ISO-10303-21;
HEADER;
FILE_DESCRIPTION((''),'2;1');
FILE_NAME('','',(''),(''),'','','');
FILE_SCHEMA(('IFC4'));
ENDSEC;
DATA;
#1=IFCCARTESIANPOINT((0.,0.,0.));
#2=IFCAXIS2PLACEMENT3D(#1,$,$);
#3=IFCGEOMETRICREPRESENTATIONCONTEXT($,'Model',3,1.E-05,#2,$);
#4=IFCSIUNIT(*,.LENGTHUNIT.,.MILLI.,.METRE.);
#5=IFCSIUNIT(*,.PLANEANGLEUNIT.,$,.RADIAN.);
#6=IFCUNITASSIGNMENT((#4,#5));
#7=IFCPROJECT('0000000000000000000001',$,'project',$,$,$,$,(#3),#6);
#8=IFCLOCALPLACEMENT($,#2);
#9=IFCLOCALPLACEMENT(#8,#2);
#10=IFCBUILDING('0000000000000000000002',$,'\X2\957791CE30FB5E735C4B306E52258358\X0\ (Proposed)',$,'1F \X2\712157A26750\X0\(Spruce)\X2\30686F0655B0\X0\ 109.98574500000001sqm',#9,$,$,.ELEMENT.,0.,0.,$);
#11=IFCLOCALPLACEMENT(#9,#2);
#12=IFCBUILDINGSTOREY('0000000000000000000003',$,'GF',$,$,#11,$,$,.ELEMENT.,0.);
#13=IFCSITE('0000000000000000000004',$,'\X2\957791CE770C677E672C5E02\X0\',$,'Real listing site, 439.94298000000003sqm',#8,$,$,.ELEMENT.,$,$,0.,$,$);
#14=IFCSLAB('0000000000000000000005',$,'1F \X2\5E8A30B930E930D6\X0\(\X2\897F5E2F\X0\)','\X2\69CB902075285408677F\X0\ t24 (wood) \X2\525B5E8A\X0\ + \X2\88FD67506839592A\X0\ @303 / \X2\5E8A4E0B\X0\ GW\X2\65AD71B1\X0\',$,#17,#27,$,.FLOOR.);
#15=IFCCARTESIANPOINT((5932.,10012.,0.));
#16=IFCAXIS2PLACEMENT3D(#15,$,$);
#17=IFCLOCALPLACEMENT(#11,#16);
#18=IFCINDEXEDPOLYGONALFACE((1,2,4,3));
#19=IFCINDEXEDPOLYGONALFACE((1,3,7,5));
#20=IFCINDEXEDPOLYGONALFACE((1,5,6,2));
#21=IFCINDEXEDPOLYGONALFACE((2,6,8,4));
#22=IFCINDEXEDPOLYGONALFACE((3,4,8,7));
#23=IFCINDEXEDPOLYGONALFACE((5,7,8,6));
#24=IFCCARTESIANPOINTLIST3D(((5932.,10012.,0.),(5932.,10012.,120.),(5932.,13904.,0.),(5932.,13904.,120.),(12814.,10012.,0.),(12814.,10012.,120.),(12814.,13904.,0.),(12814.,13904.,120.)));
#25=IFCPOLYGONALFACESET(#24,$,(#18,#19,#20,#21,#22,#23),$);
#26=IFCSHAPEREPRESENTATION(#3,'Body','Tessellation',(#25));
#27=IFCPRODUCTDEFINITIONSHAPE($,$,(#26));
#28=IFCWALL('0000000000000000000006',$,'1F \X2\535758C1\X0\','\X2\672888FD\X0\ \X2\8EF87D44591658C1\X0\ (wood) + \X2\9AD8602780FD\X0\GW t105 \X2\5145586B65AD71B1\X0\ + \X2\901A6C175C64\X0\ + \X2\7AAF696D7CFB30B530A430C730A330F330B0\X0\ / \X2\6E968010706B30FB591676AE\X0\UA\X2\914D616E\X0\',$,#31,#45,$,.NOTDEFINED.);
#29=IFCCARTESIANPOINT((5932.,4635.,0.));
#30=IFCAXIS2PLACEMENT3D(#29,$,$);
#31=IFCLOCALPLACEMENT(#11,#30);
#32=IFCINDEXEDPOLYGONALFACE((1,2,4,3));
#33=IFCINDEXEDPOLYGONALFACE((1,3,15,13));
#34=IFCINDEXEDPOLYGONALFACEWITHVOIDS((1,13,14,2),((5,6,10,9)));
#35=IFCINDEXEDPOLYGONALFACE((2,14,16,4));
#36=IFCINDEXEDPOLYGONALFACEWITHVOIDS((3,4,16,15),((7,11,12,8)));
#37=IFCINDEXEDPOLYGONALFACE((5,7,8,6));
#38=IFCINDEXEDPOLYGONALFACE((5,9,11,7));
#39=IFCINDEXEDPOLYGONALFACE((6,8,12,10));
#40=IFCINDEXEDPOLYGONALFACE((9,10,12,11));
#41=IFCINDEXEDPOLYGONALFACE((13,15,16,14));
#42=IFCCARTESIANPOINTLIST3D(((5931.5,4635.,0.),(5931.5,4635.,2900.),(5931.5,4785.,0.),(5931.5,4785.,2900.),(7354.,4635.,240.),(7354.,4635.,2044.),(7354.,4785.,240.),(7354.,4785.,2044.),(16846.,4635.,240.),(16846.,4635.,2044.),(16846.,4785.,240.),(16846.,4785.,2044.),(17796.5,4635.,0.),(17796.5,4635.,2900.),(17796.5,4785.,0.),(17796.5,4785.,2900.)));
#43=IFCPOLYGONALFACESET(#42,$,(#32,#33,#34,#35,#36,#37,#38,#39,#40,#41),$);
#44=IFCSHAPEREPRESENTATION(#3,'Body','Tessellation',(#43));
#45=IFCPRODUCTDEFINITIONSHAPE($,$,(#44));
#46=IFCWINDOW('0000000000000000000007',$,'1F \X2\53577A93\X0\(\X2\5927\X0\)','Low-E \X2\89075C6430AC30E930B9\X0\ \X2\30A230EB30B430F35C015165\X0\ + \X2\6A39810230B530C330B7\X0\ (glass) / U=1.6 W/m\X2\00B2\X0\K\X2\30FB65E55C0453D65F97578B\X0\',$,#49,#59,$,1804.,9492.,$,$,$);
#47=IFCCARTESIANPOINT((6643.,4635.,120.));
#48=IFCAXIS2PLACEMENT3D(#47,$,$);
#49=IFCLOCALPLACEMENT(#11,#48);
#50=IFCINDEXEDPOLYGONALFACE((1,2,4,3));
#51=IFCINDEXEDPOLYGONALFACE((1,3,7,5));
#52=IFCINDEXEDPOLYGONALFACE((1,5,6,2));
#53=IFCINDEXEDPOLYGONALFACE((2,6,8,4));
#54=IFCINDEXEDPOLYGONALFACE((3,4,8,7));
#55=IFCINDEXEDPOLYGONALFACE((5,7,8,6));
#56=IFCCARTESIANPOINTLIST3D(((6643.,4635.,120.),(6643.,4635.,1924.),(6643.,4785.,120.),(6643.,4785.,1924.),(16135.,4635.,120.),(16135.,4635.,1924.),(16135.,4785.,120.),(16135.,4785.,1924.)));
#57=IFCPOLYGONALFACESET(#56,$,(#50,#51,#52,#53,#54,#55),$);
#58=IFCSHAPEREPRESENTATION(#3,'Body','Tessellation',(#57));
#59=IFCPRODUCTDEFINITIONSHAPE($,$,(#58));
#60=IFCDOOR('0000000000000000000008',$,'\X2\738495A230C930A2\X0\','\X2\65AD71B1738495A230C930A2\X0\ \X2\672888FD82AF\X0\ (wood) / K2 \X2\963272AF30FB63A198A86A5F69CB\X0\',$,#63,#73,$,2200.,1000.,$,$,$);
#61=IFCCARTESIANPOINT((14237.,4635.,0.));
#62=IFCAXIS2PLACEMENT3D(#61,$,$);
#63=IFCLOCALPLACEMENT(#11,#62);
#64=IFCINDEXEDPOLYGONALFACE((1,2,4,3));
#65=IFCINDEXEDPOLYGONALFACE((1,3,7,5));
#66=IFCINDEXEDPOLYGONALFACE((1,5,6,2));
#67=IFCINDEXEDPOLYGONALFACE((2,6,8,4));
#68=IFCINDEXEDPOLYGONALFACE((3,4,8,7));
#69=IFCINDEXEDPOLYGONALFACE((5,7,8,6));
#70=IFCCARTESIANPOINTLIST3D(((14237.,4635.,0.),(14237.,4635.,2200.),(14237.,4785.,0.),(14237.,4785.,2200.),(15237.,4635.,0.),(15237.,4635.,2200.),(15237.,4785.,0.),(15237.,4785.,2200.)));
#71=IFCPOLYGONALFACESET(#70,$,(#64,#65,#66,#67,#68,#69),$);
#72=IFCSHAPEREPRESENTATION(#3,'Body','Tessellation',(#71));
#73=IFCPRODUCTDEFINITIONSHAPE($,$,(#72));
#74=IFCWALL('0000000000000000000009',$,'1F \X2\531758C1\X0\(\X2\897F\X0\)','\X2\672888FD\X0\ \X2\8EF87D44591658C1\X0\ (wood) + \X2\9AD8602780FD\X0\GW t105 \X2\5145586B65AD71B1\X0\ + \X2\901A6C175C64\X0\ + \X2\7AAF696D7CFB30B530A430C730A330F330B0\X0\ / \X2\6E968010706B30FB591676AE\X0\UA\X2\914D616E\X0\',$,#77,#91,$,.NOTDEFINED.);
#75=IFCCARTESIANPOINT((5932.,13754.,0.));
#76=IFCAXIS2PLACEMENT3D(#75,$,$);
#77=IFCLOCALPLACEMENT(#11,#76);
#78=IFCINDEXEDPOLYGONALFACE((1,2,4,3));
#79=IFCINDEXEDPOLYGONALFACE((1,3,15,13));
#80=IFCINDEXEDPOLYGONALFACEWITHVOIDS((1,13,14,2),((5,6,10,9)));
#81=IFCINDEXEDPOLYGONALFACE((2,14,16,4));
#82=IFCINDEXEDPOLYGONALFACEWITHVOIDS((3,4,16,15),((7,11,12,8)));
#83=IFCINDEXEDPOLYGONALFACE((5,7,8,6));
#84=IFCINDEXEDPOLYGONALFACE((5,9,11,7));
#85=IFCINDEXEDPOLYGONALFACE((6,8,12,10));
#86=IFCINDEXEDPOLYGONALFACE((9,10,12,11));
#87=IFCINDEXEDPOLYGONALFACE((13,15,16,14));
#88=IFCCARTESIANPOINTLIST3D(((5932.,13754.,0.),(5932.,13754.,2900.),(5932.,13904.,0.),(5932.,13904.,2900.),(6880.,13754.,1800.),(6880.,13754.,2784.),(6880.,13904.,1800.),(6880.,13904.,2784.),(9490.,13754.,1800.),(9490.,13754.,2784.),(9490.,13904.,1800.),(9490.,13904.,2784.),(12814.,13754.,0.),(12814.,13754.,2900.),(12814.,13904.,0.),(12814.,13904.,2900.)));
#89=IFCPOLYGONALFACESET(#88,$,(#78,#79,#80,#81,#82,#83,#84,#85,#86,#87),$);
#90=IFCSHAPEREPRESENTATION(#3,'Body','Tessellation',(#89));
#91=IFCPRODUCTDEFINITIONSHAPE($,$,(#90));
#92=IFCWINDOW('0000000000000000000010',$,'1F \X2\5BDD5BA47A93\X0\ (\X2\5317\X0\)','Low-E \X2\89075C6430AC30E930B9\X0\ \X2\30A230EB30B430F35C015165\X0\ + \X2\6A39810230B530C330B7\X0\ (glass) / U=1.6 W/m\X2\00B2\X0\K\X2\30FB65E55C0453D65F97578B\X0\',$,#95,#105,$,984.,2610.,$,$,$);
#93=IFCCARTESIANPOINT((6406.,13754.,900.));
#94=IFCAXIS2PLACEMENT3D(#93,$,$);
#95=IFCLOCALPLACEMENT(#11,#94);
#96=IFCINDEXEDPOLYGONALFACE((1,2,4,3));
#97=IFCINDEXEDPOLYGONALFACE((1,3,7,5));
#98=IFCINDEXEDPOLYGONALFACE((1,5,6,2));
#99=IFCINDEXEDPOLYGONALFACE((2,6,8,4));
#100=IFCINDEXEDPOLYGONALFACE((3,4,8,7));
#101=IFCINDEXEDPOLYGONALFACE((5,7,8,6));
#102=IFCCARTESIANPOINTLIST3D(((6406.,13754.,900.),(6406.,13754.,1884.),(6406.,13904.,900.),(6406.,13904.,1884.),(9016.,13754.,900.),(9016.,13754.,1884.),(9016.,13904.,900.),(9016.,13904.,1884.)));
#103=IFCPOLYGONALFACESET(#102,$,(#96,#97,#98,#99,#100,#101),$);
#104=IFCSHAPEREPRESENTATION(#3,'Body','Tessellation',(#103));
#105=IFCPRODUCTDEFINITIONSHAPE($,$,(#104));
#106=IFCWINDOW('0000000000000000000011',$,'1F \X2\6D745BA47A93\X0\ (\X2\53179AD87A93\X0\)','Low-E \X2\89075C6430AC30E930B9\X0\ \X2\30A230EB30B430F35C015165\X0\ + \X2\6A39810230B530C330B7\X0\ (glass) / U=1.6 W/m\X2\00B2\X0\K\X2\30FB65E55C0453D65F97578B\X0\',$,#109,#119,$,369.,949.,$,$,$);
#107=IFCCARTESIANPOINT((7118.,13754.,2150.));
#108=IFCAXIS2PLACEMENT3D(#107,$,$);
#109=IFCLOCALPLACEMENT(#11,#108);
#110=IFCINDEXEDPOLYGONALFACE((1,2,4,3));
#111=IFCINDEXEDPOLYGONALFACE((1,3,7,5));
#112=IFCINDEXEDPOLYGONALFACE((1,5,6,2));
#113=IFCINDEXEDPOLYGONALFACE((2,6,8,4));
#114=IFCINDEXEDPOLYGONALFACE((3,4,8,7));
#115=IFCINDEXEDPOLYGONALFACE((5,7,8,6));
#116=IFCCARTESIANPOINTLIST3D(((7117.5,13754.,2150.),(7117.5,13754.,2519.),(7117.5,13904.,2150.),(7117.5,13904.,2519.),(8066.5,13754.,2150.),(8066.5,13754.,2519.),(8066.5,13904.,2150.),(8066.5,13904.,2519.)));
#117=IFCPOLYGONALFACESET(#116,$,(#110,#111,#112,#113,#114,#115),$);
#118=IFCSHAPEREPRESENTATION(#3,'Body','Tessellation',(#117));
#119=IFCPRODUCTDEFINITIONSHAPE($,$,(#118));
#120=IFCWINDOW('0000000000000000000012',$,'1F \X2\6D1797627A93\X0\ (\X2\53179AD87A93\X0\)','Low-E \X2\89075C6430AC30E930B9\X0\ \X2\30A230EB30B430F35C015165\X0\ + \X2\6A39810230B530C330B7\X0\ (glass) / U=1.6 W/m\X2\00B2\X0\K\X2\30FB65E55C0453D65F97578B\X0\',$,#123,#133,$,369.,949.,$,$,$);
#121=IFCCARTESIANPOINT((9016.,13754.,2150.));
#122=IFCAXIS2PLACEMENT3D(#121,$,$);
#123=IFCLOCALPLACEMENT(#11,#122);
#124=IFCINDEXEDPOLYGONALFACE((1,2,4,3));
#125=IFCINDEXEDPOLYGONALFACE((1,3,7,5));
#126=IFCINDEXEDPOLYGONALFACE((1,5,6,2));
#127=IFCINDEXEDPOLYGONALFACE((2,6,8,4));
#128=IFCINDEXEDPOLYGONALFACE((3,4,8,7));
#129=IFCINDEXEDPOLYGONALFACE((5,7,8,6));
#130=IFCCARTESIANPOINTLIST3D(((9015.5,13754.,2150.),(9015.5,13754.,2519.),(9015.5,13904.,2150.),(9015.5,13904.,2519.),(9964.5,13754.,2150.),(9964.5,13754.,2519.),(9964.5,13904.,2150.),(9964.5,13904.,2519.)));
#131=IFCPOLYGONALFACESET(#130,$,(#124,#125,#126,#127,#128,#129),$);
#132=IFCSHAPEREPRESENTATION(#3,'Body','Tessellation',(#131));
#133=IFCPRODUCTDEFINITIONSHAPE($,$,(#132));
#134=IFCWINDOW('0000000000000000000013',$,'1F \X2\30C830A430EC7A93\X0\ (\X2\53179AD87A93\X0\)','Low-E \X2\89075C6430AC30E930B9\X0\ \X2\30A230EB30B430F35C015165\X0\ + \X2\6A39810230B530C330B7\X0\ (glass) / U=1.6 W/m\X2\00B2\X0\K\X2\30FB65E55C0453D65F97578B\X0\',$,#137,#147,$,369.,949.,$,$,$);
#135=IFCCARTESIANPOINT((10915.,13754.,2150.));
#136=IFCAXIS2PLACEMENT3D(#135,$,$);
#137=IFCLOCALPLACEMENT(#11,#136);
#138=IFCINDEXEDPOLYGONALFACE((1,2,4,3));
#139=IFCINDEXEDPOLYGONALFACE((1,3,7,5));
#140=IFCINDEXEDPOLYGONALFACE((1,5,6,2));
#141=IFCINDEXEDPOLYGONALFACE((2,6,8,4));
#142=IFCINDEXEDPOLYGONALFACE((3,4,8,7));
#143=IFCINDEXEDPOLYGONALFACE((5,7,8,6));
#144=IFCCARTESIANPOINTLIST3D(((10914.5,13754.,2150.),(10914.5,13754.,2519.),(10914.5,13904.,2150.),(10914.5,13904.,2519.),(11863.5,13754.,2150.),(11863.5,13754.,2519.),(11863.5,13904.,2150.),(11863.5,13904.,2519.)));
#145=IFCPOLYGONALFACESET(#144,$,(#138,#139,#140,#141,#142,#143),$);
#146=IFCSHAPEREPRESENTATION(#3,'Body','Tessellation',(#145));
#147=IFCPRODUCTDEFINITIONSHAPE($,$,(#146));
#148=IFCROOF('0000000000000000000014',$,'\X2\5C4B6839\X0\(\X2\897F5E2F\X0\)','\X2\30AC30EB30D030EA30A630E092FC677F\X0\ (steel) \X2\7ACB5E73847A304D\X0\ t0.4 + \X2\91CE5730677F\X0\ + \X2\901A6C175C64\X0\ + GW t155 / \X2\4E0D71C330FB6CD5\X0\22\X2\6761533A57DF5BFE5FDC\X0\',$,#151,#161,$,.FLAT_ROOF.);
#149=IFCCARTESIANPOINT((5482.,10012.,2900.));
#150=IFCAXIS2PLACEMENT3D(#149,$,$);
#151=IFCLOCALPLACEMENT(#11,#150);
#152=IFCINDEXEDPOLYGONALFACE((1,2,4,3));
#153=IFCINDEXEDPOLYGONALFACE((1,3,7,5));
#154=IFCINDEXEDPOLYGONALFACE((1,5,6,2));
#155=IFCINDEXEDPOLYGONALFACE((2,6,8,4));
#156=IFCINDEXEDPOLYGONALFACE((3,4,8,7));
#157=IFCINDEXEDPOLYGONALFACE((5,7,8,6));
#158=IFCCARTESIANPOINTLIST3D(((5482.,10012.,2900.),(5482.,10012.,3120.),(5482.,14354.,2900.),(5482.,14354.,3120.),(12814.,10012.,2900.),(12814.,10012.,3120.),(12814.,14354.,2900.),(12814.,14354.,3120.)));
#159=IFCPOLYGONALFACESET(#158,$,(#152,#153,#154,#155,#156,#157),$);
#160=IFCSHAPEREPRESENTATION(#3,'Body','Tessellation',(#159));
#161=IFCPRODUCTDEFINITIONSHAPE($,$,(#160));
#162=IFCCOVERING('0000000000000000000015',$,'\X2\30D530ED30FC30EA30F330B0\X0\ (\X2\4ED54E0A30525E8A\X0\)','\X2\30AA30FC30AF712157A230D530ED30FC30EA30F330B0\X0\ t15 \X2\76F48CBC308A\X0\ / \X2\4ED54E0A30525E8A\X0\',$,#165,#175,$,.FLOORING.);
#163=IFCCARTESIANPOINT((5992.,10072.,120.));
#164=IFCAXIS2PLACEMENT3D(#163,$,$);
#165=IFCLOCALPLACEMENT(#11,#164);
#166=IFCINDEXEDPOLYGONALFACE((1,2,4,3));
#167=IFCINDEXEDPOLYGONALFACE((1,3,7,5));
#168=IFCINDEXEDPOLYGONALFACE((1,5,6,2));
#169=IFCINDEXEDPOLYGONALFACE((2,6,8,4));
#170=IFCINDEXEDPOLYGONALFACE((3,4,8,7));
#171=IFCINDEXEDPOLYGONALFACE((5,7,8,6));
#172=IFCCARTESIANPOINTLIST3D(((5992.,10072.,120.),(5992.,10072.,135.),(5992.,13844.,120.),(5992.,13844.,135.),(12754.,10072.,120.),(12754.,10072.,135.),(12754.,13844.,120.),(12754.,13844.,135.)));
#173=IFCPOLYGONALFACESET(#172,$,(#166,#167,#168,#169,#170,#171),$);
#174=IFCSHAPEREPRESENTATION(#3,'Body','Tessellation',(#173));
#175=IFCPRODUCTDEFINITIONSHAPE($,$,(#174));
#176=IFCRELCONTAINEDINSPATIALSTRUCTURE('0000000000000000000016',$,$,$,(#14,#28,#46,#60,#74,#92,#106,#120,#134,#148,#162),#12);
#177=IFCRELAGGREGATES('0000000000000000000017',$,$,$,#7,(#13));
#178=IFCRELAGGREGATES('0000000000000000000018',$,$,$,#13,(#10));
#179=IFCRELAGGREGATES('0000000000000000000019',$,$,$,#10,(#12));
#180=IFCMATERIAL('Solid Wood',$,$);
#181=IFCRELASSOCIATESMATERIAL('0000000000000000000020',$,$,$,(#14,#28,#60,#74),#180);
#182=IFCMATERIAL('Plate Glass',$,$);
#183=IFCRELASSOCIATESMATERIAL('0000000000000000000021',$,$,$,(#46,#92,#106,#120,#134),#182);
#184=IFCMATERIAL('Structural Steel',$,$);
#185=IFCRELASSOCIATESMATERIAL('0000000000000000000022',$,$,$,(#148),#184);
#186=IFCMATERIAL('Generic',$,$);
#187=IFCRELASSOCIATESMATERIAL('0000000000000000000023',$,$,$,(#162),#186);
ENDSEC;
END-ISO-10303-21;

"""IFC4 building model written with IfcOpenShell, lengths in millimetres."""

from ifc_helpers import new_model, si_unit, frame, frame_2d, origin, place, context, project, spatial, rectangle, extrude, material, element, fill, save


model = new_model("IFC4")

# Units and contexts
model_context = context("Model", 3, precision=1e-05, world=origin())
ifc_project = project(units=[si_unit("LENGTHUNIT", "METRE", prefix="MILLI"), si_unit("PLANEANGLEUNIT", "RADIAN")], contexts=[model_context])

# Site, building, storey
site_placement = place(None, origin())
site = spatial("IfcSite", under=ifc_project, at=site_placement, Name="長野県松本市", ObjectType="Real listing site, 439.94298000000003sqm", CompositionType="ELEMENT", RefElevation=0.0)
building_placement = place(site_placement, origin())
building = spatial("IfcBuilding", under=site, at=building_placement, Name="長野・平屋の別荘 (Proposed)", ObjectType="1F 無垢材(Spruce)と漆喰 109.98574500000001sqm", CompositionType="ELEMENT", ElevationOfRefHeight=0.0, ElevationOfTerrain=0.0)
storey_placement = place(building_placement, origin())
storey = spatial("IfcBuildingStorey", under=building, at=storey_placement, Name="GF", CompositionType="ELEMENT", Elevation=0.0)

# Slab
ifc_material_1 = material(Name="Solid Wood")
slab_1_placement = place(storey_placement, frame((5932.0, 10012.0, 0.0)))
element("IfcSlab", 1, at=slab_1_placement, inside=storey, material=ifc_material_1, Name="1F 床スラブ(西帯)", Description="構造用合板 t24 (wood) 剛床 + 製材根太 @303 / 床下 GW断熱", PredefinedType="FLOOR", context=model_context, shape_type="SweptSolid", body=[
    extrude(rectangle(XDim=6882.0, YDim=3892.0, at=frame_2d((3441.0, 1946.0))), frame((5932.0, 10012.0, 0.0)), (0.0, 0.0, 1.0), 120.0),
])

# Wall, openings, window, door
wall_1_placement = place(storey_placement, frame((5932.0, 4635.0, 0.0)))
wall_1 = element("IfcWall", 2, at=wall_1_placement, inside=storey, material=ifc_material_1, Name="1F 南壁", Description="木製 軸組外壁 (wood) + 高性能GW t105 充填断熱 + 通気層 + 窯業系サイディング / 準耐火・外皮UA配慮", PredefinedType="NOTDEFINED", context=model_context, shape_type="SweptSolid", body=[
    extrude(rectangle(XDim=11865.0, YDim=150.0, at=frame_2d((5932.0, 75.0))), frame((5932.0, 4635.0, 0.0)), (0.0, 0.0, 1.0), 2900.0),
])
opening_1_placement = place(storey_placement, frame((6643.0, 4635.0, 120.0)))
opening_1 = element("IfcOpeningElement", 3, at=opening_1_placement, cuts=wall_1, PredefinedType="NOTDEFINED", context=model_context, shape_type="SweptSolid", body=[
    extrude(rectangle(XDim=9492.0, YDim=150.0, at=frame_2d((4746.0, 75.0))), frame((6643.0, 4635.0, 120.0)), (0.0, 0.0, 1.0), 1804.0),
])
opening_2_placement = place(storey_placement, frame((14237.0, 4635.0, 0.0)))
opening_2 = element("IfcOpeningElement", 4, at=opening_2_placement, cuts=wall_1, PredefinedType="NOTDEFINED", context=model_context, shape_type="SweptSolid", body=[
    extrude(rectangle(XDim=1000.0, YDim=150.0, at=frame_2d((500.0, 75.0))), frame((14237.0, 4635.0, 0.0)), (0.0, 0.0, 1.0), 2200.0),
])
ifc_material_2 = material(Name="Plate Glass")
window_1_placement = place(storey_placement, frame((6643.0, 4635.0, 120.0)))
window_1 = element("IfcWindow", 5, at=window_1_placement, inside=storey, material=ifc_material_2, Name="1F 南窓(大)", Description="Low-E 複層ガラス アルゴン封入 + 樹脂サッシ (glass) / U=1.6 W/m²K・日射取得型", OverallHeight=1804.0, OverallWidth=9492.0, context=model_context, shape_type="SweptSolid", body=[
    extrude(rectangle(XDim=9492.0, YDim=150.0, at=frame_2d((4746.0, 75.0))), frame((6643.0, 4635.0, 120.0)), (0.0, 0.0, 1.0), 1804.0),
])
fill(opening_1, window_1)
door_1_placement = place(storey_placement, frame((14237.0, 4635.0, 0.0)))
door_1 = element("IfcDoor", 6, at=door_1_placement, inside=storey, material=ifc_material_1, Name="玄関ドア", Description="断熱玄関ドア 木製芯 (wood) / K2 防犯・採風機構", OverallHeight=2200.0, OverallWidth=1000.0, context=model_context, shape_type="SweptSolid", body=[
    extrude(rectangle(XDim=1000.0, YDim=150.0, at=frame_2d((500.0, 75.0))), frame((14237.0, 4635.0, 0.0)), (0.0, 0.0, 1.0), 2200.0),
])
fill(opening_2, door_1)

# Wall, openings, windows
wall_2_placement = place(storey_placement, frame((5932.0, 13754.0, 0.0)))
wall_2 = element("IfcWall", 7, at=wall_2_placement, inside=storey, material=ifc_material_1, Name="1F 北壁(西)", Description="木製 軸組外壁 (wood) + 高性能GW t105 充填断熱 + 通気層 + 窯業系サイディング / 準耐火・外皮UA配慮", PredefinedType="NOTDEFINED", context=model_context, shape_type="SweptSolid", body=[
    extrude(rectangle(XDim=6882.0, YDim=150.0, at=frame_2d((3441.0, 75.0))), frame((5932.0, 13754.0, 0.0)), (0.0, 0.0, 1.0), 2900.0),
])
opening_3_placement = place(storey_placement, frame((6406.0, 13754.0, 900.0)))
opening_3 = element("IfcOpeningElement", 8, at=opening_3_placement, cuts=wall_2, PredefinedType="NOTDEFINED", context=model_context, shape_type="SweptSolid", body=[
    extrude(rectangle(XDim=2610.0, YDim=150.0, at=frame_2d((1305.0, 75.0))), frame((6406.0, 13754.0, 900.0)), (0.0, 0.0, 1.0), 984.0),
])
opening_4_placement = place(storey_placement, frame((7118.0, 13754.0, 2150.0)))
opening_4 = element("IfcOpeningElement", 9, at=opening_4_placement, cuts=wall_2, PredefinedType="NOTDEFINED", context=model_context, shape_type="SweptSolid", body=[
    extrude(rectangle(XDim=949.0, YDim=150.0, at=frame_2d((474.0, 75.0))), frame((7118.0, 13754.0, 2150.0)), (0.0, 0.0, 1.0), 369.0),
])
opening_5_placement = place(storey_placement, frame((9016.0, 13754.0, 2150.0)))
opening_5 = element("IfcOpeningElement", 10, at=opening_5_placement, cuts=wall_2, PredefinedType="NOTDEFINED", context=model_context, shape_type="SweptSolid", body=[
    extrude(rectangle(XDim=949.0, YDim=150.0, at=frame_2d((474.0, 75.0))), frame((9016.0, 13754.0, 2150.0)), (0.0, 0.0, 1.0), 369.0),
])
opening_6_placement = place(storey_placement, frame((10915.0, 13754.0, 2150.0)))
opening_6 = element("IfcOpeningElement", 11, at=opening_6_placement, cuts=wall_2, PredefinedType="NOTDEFINED", context=model_context, shape_type="SweptSolid", body=[
    extrude(rectangle(XDim=949.0, YDim=150.0, at=frame_2d((474.0, 75.0))), frame((10915.0, 13754.0, 2150.0)), (0.0, 0.0, 1.0), 369.0),
])
window_2_placement = place(storey_placement, frame((6406.0, 13754.0, 900.0)))
window_2 = element("IfcWindow", 12, at=window_2_placement, inside=storey, material=ifc_material_2, Name="1F 寝室窓 (北)", Description="Low-E 複層ガラス アルゴン封入 + 樹脂サッシ (glass) / U=1.6 W/m²K・日射取得型", OverallHeight=984.0, OverallWidth=2610.0, context=model_context, shape_type="SweptSolid", body=[
    extrude(rectangle(XDim=2610.0, YDim=150.0, at=frame_2d((1305.0, 75.0))), frame((6406.0, 13754.0, 900.0)), (0.0, 0.0, 1.0), 984.0),
])
fill(opening_3, window_2)
window_3_placement = place(storey_placement, frame((7118.0, 13754.0, 2150.0)))
window_3 = element("IfcWindow", 13, at=window_3_placement, inside=storey, material=ifc_material_2, Name="1F 浴室窓 (北高窓)", Description="Low-E 複層ガラス アルゴン封入 + 樹脂サッシ (glass) / U=1.6 W/m²K・日射取得型", OverallHeight=369.0, OverallWidth=949.0, context=model_context, shape_type="SweptSolid", body=[
    extrude(rectangle(XDim=949.0, YDim=150.0, at=frame_2d((474.0, 75.0))), frame((7118.0, 13754.0, 2150.0)), (0.0, 0.0, 1.0), 369.0),
])
fill(opening_4, window_3)
window_4_placement = place(storey_placement, frame((9016.0, 13754.0, 2150.0)))
window_4 = element("IfcWindow", 14, at=window_4_placement, inside=storey, material=ifc_material_2, Name="1F 洗面窓 (北高窓)", Description="Low-E 複層ガラス アルゴン封入 + 樹脂サッシ (glass) / U=1.6 W/m²K・日射取得型", OverallHeight=369.0, OverallWidth=949.0, context=model_context, shape_type="SweptSolid", body=[
    extrude(rectangle(XDim=949.0, YDim=150.0, at=frame_2d((474.0, 75.0))), frame((9016.0, 13754.0, 2150.0)), (0.0, 0.0, 1.0), 369.0),
])
fill(opening_5, window_4)
window_5_placement = place(storey_placement, frame((10915.0, 13754.0, 2150.0)))
window_5 = element("IfcWindow", 15, at=window_5_placement, inside=storey, material=ifc_material_2, Name="1F トイレ窓 (北高窓)", Description="Low-E 複層ガラス アルゴン封入 + 樹脂サッシ (glass) / U=1.6 W/m²K・日射取得型", OverallHeight=369.0, OverallWidth=949.0, context=model_context, shape_type="SweptSolid", body=[
    extrude(rectangle(XDim=949.0, YDim=150.0, at=frame_2d((474.0, 75.0))), frame((10915.0, 13754.0, 2150.0)), (0.0, 0.0, 1.0), 369.0),
])
fill(opening_6, window_5)

# Roof
ifc_material_3 = material(Name="Structural Steel")
roof_1_placement = place(storey_placement, frame((5482.0, 10012.0, 2900.0)))
element("IfcRoof", 16, at=roof_1_placement, inside=storey, material=ifc_material_3, Name="屋根(西帯)", Description="ガルバリウム鋼板 (steel) 立平葺き t0.4 + 野地板 + 通気層 + GW t155 / 不燃・法22条区域対応", PredefinedType="FLAT_ROOF", context=model_context, shape_type="SweptSolid", body=[
    extrude(rectangle(XDim=7332.0, YDim=4342.0, at=frame_2d((3666.0, 2171.0))), frame((5482.0, 10012.0, 2900.0)), (0.0, 0.0, 1.0), 220.0),
])

# Covering
ifc_material_4 = material(Name="Generic")
covering_1_placement = place(storey_placement, frame((5992.0, 10072.0, 120.0)))
element("IfcCovering", 17, at=covering_1_placement, inside=storey, material=ifc_material_4, Name="フローリング (仕上げ床)", Description="オーク無垢フローリング t15 直貼り / 仕上げ床", PredefinedType="FLOORING", context=model_context, shape_type="SweptSolid", body=[
    extrude(rectangle(XDim=6762.0, YDim=3772.0, at=frame_2d((3381.0, 1886.0))), frame((5992.0, 10072.0, 120.0)), (0.0, 0.0, 1.0), 15.0),
])

save(model, "model.ifc")
